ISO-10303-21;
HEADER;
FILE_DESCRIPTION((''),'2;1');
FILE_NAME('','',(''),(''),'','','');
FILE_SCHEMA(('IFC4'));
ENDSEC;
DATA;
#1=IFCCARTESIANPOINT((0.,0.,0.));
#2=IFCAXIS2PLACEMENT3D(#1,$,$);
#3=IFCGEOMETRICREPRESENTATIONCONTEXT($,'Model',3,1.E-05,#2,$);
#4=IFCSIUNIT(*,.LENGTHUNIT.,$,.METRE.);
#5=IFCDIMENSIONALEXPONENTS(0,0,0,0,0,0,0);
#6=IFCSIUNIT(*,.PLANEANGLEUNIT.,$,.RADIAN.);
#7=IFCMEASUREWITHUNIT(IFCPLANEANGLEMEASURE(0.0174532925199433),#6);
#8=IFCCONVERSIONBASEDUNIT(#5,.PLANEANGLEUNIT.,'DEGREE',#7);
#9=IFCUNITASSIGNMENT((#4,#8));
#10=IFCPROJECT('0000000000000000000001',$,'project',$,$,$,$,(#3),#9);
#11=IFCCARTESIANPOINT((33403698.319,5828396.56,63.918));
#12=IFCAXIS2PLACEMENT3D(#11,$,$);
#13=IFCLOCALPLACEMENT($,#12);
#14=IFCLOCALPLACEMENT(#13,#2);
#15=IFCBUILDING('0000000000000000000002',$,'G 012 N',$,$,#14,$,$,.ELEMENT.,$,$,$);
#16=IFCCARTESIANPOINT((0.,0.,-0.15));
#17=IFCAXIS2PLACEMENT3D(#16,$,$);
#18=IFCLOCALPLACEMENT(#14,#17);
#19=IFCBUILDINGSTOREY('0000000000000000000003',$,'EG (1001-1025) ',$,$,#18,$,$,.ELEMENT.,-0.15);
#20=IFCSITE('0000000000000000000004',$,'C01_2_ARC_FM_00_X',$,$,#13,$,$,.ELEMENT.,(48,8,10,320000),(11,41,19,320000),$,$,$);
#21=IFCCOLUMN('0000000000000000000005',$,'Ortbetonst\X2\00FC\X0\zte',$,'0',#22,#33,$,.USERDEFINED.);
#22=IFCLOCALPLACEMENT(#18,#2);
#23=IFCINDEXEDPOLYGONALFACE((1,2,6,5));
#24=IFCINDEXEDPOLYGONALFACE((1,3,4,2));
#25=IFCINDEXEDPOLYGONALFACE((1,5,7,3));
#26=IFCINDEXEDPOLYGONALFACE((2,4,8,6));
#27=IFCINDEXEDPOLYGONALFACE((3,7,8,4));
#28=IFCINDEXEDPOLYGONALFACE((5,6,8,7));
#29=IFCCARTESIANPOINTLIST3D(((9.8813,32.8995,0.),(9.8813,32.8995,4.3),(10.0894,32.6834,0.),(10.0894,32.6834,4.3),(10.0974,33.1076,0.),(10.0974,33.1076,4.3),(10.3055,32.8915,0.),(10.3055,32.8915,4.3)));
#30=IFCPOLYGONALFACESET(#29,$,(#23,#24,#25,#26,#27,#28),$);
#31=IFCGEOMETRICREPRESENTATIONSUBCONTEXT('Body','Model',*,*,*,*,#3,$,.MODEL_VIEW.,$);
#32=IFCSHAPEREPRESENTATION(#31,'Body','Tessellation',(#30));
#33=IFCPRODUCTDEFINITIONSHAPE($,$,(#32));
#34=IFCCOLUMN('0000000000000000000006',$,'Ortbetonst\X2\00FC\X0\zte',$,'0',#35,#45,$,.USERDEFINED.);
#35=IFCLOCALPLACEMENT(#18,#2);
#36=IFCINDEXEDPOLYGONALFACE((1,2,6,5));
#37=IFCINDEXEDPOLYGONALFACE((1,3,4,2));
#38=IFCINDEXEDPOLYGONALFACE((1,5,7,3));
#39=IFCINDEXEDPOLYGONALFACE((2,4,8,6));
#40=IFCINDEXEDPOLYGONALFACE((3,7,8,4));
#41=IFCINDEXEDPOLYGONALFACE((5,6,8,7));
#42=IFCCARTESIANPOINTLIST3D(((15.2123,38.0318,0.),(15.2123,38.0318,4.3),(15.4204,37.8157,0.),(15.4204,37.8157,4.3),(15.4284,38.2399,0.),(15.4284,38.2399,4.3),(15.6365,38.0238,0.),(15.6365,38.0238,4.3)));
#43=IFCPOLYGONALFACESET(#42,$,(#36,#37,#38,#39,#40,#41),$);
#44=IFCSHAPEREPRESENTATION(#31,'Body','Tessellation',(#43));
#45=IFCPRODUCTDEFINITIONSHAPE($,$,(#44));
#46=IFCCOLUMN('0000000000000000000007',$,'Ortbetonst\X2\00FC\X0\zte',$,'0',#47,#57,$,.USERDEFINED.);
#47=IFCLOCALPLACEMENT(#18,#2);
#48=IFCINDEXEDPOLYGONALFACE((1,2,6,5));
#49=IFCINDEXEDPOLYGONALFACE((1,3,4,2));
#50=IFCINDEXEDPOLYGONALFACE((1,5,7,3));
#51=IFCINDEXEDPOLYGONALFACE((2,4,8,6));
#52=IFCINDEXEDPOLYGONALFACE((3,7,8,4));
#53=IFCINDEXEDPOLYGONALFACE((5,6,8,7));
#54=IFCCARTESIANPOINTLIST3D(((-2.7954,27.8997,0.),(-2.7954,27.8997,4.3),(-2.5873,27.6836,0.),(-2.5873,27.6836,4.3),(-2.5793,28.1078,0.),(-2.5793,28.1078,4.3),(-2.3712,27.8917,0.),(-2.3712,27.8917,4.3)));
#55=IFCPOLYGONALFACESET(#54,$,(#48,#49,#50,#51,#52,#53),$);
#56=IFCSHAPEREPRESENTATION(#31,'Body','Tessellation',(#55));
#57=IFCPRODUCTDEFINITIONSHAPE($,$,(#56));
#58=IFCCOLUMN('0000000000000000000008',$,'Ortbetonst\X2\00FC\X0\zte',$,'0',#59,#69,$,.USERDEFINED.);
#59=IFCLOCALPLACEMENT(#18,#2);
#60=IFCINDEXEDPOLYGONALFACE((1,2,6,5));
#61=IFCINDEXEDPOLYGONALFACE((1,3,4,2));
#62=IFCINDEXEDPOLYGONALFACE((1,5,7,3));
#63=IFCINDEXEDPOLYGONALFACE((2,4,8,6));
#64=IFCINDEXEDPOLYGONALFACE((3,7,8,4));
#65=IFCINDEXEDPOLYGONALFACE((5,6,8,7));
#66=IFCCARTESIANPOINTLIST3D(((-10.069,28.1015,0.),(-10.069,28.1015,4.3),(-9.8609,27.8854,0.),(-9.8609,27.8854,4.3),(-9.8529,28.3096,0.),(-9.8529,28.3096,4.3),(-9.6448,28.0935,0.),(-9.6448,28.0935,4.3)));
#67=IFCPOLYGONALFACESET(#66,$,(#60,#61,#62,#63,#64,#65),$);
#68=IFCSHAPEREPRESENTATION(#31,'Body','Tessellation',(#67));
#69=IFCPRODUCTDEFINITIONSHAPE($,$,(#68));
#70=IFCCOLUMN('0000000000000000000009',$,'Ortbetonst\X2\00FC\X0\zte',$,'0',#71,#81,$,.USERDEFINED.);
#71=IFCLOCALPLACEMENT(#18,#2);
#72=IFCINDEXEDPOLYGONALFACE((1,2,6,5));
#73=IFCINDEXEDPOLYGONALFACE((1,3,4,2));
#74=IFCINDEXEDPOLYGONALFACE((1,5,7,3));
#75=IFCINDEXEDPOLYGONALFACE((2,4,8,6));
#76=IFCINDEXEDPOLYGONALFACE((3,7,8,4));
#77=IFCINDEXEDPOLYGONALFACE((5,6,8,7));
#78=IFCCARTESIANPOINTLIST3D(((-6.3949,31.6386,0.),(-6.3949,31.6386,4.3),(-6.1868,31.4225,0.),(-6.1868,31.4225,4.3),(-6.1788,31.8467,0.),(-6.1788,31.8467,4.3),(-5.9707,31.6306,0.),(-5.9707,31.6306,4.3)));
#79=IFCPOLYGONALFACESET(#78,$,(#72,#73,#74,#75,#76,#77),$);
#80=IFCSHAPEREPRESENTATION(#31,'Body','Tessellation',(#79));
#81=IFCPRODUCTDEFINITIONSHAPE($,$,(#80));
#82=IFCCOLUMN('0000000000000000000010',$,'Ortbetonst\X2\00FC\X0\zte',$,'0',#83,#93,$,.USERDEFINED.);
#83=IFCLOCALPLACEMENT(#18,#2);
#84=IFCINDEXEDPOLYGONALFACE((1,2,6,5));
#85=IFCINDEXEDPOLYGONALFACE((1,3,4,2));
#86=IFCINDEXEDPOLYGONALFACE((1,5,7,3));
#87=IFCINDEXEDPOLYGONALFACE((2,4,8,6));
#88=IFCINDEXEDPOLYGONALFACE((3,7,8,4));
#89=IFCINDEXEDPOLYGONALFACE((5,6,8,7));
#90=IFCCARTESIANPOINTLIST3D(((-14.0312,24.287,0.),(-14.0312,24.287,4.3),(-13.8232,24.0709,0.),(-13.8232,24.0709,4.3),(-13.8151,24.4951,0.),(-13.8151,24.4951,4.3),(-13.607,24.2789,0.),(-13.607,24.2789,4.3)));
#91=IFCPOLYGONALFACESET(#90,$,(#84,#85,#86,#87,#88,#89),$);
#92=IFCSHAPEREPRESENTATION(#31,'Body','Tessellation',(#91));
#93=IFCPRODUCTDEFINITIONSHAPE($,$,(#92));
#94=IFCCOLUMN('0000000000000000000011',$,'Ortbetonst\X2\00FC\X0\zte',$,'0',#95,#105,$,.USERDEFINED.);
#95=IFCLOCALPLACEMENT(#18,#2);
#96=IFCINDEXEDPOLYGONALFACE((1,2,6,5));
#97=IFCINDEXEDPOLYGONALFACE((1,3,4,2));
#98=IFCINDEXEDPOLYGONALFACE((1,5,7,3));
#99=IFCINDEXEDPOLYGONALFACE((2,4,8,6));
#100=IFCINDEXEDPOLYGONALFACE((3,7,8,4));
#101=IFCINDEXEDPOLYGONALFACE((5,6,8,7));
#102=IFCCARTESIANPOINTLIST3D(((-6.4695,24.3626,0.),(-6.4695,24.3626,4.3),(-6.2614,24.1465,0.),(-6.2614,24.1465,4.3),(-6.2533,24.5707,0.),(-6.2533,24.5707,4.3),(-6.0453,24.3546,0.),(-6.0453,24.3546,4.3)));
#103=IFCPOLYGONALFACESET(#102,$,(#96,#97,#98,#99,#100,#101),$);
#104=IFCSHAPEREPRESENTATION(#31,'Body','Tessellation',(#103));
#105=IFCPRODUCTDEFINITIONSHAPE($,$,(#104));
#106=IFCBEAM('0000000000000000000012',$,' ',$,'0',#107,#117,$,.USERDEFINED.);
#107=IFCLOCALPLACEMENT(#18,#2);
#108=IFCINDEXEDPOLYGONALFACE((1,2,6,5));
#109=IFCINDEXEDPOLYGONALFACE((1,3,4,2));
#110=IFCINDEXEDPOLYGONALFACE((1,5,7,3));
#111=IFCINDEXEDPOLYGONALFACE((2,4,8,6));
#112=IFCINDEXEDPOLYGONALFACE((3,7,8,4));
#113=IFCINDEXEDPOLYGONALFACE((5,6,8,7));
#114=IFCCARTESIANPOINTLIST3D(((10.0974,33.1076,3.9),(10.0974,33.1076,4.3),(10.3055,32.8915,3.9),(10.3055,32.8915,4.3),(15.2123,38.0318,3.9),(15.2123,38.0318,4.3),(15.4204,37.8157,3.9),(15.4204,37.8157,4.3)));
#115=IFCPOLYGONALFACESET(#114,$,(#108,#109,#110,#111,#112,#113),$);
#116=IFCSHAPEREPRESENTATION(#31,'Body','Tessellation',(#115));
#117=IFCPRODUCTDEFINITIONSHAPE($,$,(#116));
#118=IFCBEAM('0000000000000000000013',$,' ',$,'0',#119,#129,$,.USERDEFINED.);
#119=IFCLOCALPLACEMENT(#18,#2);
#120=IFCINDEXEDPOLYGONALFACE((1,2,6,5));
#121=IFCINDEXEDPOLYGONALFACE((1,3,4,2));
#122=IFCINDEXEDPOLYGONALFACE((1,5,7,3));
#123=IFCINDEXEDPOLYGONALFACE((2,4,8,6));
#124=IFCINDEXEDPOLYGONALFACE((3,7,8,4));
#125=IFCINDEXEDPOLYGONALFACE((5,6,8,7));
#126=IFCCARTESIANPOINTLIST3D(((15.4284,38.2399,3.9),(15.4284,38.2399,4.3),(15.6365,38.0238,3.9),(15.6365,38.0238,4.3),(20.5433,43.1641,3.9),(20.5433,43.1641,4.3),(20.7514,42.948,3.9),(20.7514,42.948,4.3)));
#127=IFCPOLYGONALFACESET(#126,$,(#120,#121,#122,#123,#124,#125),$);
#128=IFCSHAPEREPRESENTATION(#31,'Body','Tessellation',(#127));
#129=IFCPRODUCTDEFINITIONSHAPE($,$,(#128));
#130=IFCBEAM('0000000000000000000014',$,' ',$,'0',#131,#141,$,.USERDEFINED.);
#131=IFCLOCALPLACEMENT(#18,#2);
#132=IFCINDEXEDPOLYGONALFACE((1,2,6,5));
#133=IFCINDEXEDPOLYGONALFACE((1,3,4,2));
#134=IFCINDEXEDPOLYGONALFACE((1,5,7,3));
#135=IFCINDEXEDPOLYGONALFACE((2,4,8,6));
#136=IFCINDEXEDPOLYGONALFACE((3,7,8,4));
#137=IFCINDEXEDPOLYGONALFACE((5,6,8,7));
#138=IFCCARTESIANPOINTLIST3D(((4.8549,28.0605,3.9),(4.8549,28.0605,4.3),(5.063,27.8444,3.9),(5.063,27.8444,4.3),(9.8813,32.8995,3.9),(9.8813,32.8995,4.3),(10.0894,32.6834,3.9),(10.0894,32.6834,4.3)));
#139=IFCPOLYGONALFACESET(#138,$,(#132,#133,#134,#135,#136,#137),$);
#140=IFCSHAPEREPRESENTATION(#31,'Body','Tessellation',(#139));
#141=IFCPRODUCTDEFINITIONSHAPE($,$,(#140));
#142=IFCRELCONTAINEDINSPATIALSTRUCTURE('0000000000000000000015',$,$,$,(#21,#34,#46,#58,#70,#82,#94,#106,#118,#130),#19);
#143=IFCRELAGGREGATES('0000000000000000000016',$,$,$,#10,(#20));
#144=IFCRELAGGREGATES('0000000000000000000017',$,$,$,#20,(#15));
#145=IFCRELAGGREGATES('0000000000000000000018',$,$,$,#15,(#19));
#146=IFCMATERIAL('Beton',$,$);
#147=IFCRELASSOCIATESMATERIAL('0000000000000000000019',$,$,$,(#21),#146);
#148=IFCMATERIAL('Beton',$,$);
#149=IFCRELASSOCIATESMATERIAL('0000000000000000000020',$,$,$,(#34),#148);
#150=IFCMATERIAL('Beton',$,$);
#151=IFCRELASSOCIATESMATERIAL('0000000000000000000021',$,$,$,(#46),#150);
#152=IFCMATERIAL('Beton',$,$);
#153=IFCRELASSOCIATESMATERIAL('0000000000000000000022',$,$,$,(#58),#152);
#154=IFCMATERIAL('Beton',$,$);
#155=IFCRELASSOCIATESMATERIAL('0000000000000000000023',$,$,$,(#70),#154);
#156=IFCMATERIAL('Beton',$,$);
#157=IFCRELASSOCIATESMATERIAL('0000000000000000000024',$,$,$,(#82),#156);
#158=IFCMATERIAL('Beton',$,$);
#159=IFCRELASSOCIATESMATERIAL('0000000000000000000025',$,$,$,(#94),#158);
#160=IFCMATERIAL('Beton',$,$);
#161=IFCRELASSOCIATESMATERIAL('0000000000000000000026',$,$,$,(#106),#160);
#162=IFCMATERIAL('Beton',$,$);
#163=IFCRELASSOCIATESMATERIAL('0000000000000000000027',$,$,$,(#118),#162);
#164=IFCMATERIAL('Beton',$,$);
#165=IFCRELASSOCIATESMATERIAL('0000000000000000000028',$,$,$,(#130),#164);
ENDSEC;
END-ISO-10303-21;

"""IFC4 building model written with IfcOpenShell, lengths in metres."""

from ifc_helpers import new_model, entity, si_unit, converted_unit, frame, frame_2d, origin, origin_with_axes, place, context, subcontext, project, spatial, rectangle, extrude, material, element, save


model = new_model("IFC4")

# Units and contexts
model_context = context("Model", 3, precision=1e-05, world=origin())
body_context = subcontext(model_context, "Body", "Model", "MODEL_VIEW")
ifc_project = project(units=[si_unit("LENGTHUNIT", "METRE"), converted_unit("PLANEANGLEUNIT", "DEGREE", entity("IfcPlaneAngleMeasure", 0.0174532925199433), si_unit("PLANEANGLEUNIT", "RADIAN"), dimensions=[0, 0, 0, 0, 0, 0, 0])], contexts=[model_context])

# Site, building, storey
site_placement = place(None, frame((33403698.319, 5828396.56, 63.918)))
site = spatial("IfcSite", under=ifc_project, at=site_placement, Name="C01_2_ARC_FM_00_X", CompositionType="ELEMENT", RefLatitude=(48, 8, 10, 320000), RefLongitude=(11, 41, 19, 320000))
building_placement = place(site_placement, origin())
building = spatial("IfcBuilding", under=site, at=building_placement, Name="G 012 N", CompositionType="ELEMENT")
storey_placement = place(building_placement, frame((0.0, 0.0, -0.15)))
storey = spatial("IfcBuildingStorey", under=building, at=storey_placement, Name="EG (1001-1025) ", CompositionType="ELEMENT", Elevation=-0.15)

# Columns
ifc_material_1 = material(Name="Beton")
column_1_placement = place(storey_placement, frame((10.0894, 32.6834, 0.0)))
element("IfcColumn", 1, at=column_1_placement, inside=storey, material=ifc_material_1, Name="Ortbetonstüzte", ObjectType="0", PredefinedType="USERDEFINED", context=body_context, shape_type="SweptSolid", body=[
    extrude(rectangle(XDim=0.3, YDim=0.3, at=frame_2d((0.004, 0.2121), x_axis=(0.720408, 0.693551))), origin_with_axes(), (0.0, 0.0, 1.0), 4.3),
])
ifc_material_2 = material(Name="Beton")
column_2_placement = place(storey_placement, frame((15.4204, 37.8157, 0.0)))
element("IfcColumn", 2, at=column_2_placement, inside=storey, material=ifc_material_2, Name="Ortbetonstüzte", ObjectType="0", PredefinedType="USERDEFINED", context=body_context, shape_type="SweptSolid", body=[
    extrude(rectangle(XDim=0.3, YDim=0.3, at=frame_2d((0.004, 0.2121), x_axis=(0.720408, 0.693551))), origin_with_axes(), (0.0, 0.0, 1.0), 4.3),
])
ifc_material_3 = material(Name="Beton")
column_3_placement = place(storey_placement, frame((-2.5873, 27.6836, 0.0)))
element("IfcColumn", 3, at=column_3_placement, inside=storey, material=ifc_material_3, Name="Ortbetonstüzte", ObjectType="0", PredefinedType="USERDEFINED", context=body_context, shape_type="SweptSolid", body=[
    extrude(rectangle(XDim=0.3, YDim=0.3, at=frame_2d((0.004, 0.2121), x_axis=(0.720408, 0.693551))), origin_with_axes(), (0.0, 0.0, 1.0), 4.3),
])
ifc_material_4 = material(Name="Beton")
column_4_placement = place(storey_placement, frame((-9.8609, 27.8854, 0.0)))
element("IfcColumn", 4, at=column_4_placement, inside=storey, material=ifc_material_4, Name="Ortbetonstüzte", ObjectType="0", PredefinedType="USERDEFINED", context=body_context, shape_type="SweptSolid", body=[
    extrude(rectangle(XDim=0.3, YDim=0.3, at=frame_2d((0.004, 0.2121), x_axis=(0.720408, 0.693551))), origin_with_axes(), (0.0, 0.0, 1.0), 4.3),
])
ifc_material_5 = material(Name="Beton")
column_5_placement = place(storey_placement, frame((-6.1868, 31.4225, 0.0)))
element("IfcColumn", 5, at=column_5_placement, inside=storey, material=ifc_material_5, Name="Ortbetonstüzte", ObjectType="0", PredefinedType="USERDEFINED", context=body_context, shape_type="SweptSolid", body=[
    extrude(rectangle(XDim=0.3, YDim=0.3, at=frame_2d((0.004, 0.2121), x_axis=(0.720408, 0.693551))), origin_with_axes(), (0.0, 0.0, 1.0), 4.3),
])
ifc_material_6 = material(Name="Beton")
column_6_placement = place(storey_placement, frame((-13.8232, 24.0709, 0.0)))
element("IfcColumn", 6, at=column_6_placement, inside=storey, material=ifc_material_6, Name="Ortbetonstüzte", ObjectType="0", PredefinedType="USERDEFINED", context=body_context, shape_type="SweptSolid", body=[
    extrude(rectangle(XDim=0.3, YDim=0.3, at=frame_2d((0.004, 0.2121), x_axis=(0.720408, 0.693551))), origin_with_axes(), (0.0, 0.0, 1.0), 4.3),
])
ifc_material_7 = material(Name="Beton")
column_7_placement = place(storey_placement, frame((-6.2614, 24.1465, 0.0)))
element("IfcColumn", 7, at=column_7_placement, inside=storey, material=ifc_material_7, Name="Ortbetonstüzte", ObjectType="0", PredefinedType="USERDEFINED", context=body_context, shape_type="SweptSolid", body=[
    extrude(rectangle(XDim=0.3, YDim=0.3, at=frame_2d((0.004, 0.2121), x_axis=(0.720408, 0.693551))), origin_with_axes(), (0.0, 0.0, 1.0), 4.3),
])

# Beams
ifc_material_8 = material(Name="Beton")
beam_1_placement = place(storey_placement, frame((10.3055, 32.8915, 3.9), z_axis=(0.0, 0.0, 1.0), x_axis=(0.720408, 0.693551, 0.0)))
element("IfcBeam", 8, at=beam_1_placement, inside=storey, material=ifc_material_8, Name=" ", ObjectType="0", PredefinedType="USERDEFINED", context=body_context, shape_type="SweptSolid", body=[
    extrude(rectangle(XDim=0.3, YDim=0.4, at=frame_2d((0.15, 0.2), x_axis=(1.0, 0.0))), frame((0.0, 0.0, 0.0), z_axis=(1.0, 0.0, 0.0), x_axis=(0.0, 1.0, 0.0)), (0.0, 0.0, 1.0), 7.1),
])
ifc_material_9 = material(Name="Beton")
beam_2_placement = place(storey_placement, frame((15.6365, 38.0238, 3.9), z_axis=(0.0, 0.0, 1.0), x_axis=(0.720408, 0.693551, 0.0)))
element("IfcBeam", 9, at=beam_2_placement, inside=storey, material=ifc_material_9, Name=" ", ObjectType="0", PredefinedType="USERDEFINED", context=body_context, shape_type="SweptSolid", body=[
    extrude(rectangle(XDim=0.3, YDim=0.4, at=frame_2d((0.15, 0.2), x_axis=(1.0, 0.0))), frame((0.0, 0.0, 0.0), z_axis=(1.0, 0.0, 0.0), x_axis=(0.0, 1.0, 0.0)), (0.0, 0.0, 1.0), 7.1),
])
ifc_material_10 = material(Name="Beton")
beam_3_placement = place(storey_placement, frame((9.8813, 32.8995, 3.9), z_axis=(0.0, 0.0, 1.0), x_axis=(-0.720408, -0.693551, 0.0)))
element("IfcBeam", 10, at=beam_3_placement, inside=storey, material=ifc_material_10, Name=" ", ObjectType="0", PredefinedType="USERDEFINED", context=body_context, shape_type="SweptSolid", body=[
    extrude(rectangle(XDim=0.3, YDim=0.4, at=frame_2d((0.15, 0.2), x_axis=(1.0, 0.0))), frame((0.0, 0.0, 0.0), z_axis=(1.0, 0.0, 0.0), x_axis=(0.0, 1.0, 0.0)), (0.0, 0.0, 1.0), 6.9771),
])

save(model, "model.ifc")
